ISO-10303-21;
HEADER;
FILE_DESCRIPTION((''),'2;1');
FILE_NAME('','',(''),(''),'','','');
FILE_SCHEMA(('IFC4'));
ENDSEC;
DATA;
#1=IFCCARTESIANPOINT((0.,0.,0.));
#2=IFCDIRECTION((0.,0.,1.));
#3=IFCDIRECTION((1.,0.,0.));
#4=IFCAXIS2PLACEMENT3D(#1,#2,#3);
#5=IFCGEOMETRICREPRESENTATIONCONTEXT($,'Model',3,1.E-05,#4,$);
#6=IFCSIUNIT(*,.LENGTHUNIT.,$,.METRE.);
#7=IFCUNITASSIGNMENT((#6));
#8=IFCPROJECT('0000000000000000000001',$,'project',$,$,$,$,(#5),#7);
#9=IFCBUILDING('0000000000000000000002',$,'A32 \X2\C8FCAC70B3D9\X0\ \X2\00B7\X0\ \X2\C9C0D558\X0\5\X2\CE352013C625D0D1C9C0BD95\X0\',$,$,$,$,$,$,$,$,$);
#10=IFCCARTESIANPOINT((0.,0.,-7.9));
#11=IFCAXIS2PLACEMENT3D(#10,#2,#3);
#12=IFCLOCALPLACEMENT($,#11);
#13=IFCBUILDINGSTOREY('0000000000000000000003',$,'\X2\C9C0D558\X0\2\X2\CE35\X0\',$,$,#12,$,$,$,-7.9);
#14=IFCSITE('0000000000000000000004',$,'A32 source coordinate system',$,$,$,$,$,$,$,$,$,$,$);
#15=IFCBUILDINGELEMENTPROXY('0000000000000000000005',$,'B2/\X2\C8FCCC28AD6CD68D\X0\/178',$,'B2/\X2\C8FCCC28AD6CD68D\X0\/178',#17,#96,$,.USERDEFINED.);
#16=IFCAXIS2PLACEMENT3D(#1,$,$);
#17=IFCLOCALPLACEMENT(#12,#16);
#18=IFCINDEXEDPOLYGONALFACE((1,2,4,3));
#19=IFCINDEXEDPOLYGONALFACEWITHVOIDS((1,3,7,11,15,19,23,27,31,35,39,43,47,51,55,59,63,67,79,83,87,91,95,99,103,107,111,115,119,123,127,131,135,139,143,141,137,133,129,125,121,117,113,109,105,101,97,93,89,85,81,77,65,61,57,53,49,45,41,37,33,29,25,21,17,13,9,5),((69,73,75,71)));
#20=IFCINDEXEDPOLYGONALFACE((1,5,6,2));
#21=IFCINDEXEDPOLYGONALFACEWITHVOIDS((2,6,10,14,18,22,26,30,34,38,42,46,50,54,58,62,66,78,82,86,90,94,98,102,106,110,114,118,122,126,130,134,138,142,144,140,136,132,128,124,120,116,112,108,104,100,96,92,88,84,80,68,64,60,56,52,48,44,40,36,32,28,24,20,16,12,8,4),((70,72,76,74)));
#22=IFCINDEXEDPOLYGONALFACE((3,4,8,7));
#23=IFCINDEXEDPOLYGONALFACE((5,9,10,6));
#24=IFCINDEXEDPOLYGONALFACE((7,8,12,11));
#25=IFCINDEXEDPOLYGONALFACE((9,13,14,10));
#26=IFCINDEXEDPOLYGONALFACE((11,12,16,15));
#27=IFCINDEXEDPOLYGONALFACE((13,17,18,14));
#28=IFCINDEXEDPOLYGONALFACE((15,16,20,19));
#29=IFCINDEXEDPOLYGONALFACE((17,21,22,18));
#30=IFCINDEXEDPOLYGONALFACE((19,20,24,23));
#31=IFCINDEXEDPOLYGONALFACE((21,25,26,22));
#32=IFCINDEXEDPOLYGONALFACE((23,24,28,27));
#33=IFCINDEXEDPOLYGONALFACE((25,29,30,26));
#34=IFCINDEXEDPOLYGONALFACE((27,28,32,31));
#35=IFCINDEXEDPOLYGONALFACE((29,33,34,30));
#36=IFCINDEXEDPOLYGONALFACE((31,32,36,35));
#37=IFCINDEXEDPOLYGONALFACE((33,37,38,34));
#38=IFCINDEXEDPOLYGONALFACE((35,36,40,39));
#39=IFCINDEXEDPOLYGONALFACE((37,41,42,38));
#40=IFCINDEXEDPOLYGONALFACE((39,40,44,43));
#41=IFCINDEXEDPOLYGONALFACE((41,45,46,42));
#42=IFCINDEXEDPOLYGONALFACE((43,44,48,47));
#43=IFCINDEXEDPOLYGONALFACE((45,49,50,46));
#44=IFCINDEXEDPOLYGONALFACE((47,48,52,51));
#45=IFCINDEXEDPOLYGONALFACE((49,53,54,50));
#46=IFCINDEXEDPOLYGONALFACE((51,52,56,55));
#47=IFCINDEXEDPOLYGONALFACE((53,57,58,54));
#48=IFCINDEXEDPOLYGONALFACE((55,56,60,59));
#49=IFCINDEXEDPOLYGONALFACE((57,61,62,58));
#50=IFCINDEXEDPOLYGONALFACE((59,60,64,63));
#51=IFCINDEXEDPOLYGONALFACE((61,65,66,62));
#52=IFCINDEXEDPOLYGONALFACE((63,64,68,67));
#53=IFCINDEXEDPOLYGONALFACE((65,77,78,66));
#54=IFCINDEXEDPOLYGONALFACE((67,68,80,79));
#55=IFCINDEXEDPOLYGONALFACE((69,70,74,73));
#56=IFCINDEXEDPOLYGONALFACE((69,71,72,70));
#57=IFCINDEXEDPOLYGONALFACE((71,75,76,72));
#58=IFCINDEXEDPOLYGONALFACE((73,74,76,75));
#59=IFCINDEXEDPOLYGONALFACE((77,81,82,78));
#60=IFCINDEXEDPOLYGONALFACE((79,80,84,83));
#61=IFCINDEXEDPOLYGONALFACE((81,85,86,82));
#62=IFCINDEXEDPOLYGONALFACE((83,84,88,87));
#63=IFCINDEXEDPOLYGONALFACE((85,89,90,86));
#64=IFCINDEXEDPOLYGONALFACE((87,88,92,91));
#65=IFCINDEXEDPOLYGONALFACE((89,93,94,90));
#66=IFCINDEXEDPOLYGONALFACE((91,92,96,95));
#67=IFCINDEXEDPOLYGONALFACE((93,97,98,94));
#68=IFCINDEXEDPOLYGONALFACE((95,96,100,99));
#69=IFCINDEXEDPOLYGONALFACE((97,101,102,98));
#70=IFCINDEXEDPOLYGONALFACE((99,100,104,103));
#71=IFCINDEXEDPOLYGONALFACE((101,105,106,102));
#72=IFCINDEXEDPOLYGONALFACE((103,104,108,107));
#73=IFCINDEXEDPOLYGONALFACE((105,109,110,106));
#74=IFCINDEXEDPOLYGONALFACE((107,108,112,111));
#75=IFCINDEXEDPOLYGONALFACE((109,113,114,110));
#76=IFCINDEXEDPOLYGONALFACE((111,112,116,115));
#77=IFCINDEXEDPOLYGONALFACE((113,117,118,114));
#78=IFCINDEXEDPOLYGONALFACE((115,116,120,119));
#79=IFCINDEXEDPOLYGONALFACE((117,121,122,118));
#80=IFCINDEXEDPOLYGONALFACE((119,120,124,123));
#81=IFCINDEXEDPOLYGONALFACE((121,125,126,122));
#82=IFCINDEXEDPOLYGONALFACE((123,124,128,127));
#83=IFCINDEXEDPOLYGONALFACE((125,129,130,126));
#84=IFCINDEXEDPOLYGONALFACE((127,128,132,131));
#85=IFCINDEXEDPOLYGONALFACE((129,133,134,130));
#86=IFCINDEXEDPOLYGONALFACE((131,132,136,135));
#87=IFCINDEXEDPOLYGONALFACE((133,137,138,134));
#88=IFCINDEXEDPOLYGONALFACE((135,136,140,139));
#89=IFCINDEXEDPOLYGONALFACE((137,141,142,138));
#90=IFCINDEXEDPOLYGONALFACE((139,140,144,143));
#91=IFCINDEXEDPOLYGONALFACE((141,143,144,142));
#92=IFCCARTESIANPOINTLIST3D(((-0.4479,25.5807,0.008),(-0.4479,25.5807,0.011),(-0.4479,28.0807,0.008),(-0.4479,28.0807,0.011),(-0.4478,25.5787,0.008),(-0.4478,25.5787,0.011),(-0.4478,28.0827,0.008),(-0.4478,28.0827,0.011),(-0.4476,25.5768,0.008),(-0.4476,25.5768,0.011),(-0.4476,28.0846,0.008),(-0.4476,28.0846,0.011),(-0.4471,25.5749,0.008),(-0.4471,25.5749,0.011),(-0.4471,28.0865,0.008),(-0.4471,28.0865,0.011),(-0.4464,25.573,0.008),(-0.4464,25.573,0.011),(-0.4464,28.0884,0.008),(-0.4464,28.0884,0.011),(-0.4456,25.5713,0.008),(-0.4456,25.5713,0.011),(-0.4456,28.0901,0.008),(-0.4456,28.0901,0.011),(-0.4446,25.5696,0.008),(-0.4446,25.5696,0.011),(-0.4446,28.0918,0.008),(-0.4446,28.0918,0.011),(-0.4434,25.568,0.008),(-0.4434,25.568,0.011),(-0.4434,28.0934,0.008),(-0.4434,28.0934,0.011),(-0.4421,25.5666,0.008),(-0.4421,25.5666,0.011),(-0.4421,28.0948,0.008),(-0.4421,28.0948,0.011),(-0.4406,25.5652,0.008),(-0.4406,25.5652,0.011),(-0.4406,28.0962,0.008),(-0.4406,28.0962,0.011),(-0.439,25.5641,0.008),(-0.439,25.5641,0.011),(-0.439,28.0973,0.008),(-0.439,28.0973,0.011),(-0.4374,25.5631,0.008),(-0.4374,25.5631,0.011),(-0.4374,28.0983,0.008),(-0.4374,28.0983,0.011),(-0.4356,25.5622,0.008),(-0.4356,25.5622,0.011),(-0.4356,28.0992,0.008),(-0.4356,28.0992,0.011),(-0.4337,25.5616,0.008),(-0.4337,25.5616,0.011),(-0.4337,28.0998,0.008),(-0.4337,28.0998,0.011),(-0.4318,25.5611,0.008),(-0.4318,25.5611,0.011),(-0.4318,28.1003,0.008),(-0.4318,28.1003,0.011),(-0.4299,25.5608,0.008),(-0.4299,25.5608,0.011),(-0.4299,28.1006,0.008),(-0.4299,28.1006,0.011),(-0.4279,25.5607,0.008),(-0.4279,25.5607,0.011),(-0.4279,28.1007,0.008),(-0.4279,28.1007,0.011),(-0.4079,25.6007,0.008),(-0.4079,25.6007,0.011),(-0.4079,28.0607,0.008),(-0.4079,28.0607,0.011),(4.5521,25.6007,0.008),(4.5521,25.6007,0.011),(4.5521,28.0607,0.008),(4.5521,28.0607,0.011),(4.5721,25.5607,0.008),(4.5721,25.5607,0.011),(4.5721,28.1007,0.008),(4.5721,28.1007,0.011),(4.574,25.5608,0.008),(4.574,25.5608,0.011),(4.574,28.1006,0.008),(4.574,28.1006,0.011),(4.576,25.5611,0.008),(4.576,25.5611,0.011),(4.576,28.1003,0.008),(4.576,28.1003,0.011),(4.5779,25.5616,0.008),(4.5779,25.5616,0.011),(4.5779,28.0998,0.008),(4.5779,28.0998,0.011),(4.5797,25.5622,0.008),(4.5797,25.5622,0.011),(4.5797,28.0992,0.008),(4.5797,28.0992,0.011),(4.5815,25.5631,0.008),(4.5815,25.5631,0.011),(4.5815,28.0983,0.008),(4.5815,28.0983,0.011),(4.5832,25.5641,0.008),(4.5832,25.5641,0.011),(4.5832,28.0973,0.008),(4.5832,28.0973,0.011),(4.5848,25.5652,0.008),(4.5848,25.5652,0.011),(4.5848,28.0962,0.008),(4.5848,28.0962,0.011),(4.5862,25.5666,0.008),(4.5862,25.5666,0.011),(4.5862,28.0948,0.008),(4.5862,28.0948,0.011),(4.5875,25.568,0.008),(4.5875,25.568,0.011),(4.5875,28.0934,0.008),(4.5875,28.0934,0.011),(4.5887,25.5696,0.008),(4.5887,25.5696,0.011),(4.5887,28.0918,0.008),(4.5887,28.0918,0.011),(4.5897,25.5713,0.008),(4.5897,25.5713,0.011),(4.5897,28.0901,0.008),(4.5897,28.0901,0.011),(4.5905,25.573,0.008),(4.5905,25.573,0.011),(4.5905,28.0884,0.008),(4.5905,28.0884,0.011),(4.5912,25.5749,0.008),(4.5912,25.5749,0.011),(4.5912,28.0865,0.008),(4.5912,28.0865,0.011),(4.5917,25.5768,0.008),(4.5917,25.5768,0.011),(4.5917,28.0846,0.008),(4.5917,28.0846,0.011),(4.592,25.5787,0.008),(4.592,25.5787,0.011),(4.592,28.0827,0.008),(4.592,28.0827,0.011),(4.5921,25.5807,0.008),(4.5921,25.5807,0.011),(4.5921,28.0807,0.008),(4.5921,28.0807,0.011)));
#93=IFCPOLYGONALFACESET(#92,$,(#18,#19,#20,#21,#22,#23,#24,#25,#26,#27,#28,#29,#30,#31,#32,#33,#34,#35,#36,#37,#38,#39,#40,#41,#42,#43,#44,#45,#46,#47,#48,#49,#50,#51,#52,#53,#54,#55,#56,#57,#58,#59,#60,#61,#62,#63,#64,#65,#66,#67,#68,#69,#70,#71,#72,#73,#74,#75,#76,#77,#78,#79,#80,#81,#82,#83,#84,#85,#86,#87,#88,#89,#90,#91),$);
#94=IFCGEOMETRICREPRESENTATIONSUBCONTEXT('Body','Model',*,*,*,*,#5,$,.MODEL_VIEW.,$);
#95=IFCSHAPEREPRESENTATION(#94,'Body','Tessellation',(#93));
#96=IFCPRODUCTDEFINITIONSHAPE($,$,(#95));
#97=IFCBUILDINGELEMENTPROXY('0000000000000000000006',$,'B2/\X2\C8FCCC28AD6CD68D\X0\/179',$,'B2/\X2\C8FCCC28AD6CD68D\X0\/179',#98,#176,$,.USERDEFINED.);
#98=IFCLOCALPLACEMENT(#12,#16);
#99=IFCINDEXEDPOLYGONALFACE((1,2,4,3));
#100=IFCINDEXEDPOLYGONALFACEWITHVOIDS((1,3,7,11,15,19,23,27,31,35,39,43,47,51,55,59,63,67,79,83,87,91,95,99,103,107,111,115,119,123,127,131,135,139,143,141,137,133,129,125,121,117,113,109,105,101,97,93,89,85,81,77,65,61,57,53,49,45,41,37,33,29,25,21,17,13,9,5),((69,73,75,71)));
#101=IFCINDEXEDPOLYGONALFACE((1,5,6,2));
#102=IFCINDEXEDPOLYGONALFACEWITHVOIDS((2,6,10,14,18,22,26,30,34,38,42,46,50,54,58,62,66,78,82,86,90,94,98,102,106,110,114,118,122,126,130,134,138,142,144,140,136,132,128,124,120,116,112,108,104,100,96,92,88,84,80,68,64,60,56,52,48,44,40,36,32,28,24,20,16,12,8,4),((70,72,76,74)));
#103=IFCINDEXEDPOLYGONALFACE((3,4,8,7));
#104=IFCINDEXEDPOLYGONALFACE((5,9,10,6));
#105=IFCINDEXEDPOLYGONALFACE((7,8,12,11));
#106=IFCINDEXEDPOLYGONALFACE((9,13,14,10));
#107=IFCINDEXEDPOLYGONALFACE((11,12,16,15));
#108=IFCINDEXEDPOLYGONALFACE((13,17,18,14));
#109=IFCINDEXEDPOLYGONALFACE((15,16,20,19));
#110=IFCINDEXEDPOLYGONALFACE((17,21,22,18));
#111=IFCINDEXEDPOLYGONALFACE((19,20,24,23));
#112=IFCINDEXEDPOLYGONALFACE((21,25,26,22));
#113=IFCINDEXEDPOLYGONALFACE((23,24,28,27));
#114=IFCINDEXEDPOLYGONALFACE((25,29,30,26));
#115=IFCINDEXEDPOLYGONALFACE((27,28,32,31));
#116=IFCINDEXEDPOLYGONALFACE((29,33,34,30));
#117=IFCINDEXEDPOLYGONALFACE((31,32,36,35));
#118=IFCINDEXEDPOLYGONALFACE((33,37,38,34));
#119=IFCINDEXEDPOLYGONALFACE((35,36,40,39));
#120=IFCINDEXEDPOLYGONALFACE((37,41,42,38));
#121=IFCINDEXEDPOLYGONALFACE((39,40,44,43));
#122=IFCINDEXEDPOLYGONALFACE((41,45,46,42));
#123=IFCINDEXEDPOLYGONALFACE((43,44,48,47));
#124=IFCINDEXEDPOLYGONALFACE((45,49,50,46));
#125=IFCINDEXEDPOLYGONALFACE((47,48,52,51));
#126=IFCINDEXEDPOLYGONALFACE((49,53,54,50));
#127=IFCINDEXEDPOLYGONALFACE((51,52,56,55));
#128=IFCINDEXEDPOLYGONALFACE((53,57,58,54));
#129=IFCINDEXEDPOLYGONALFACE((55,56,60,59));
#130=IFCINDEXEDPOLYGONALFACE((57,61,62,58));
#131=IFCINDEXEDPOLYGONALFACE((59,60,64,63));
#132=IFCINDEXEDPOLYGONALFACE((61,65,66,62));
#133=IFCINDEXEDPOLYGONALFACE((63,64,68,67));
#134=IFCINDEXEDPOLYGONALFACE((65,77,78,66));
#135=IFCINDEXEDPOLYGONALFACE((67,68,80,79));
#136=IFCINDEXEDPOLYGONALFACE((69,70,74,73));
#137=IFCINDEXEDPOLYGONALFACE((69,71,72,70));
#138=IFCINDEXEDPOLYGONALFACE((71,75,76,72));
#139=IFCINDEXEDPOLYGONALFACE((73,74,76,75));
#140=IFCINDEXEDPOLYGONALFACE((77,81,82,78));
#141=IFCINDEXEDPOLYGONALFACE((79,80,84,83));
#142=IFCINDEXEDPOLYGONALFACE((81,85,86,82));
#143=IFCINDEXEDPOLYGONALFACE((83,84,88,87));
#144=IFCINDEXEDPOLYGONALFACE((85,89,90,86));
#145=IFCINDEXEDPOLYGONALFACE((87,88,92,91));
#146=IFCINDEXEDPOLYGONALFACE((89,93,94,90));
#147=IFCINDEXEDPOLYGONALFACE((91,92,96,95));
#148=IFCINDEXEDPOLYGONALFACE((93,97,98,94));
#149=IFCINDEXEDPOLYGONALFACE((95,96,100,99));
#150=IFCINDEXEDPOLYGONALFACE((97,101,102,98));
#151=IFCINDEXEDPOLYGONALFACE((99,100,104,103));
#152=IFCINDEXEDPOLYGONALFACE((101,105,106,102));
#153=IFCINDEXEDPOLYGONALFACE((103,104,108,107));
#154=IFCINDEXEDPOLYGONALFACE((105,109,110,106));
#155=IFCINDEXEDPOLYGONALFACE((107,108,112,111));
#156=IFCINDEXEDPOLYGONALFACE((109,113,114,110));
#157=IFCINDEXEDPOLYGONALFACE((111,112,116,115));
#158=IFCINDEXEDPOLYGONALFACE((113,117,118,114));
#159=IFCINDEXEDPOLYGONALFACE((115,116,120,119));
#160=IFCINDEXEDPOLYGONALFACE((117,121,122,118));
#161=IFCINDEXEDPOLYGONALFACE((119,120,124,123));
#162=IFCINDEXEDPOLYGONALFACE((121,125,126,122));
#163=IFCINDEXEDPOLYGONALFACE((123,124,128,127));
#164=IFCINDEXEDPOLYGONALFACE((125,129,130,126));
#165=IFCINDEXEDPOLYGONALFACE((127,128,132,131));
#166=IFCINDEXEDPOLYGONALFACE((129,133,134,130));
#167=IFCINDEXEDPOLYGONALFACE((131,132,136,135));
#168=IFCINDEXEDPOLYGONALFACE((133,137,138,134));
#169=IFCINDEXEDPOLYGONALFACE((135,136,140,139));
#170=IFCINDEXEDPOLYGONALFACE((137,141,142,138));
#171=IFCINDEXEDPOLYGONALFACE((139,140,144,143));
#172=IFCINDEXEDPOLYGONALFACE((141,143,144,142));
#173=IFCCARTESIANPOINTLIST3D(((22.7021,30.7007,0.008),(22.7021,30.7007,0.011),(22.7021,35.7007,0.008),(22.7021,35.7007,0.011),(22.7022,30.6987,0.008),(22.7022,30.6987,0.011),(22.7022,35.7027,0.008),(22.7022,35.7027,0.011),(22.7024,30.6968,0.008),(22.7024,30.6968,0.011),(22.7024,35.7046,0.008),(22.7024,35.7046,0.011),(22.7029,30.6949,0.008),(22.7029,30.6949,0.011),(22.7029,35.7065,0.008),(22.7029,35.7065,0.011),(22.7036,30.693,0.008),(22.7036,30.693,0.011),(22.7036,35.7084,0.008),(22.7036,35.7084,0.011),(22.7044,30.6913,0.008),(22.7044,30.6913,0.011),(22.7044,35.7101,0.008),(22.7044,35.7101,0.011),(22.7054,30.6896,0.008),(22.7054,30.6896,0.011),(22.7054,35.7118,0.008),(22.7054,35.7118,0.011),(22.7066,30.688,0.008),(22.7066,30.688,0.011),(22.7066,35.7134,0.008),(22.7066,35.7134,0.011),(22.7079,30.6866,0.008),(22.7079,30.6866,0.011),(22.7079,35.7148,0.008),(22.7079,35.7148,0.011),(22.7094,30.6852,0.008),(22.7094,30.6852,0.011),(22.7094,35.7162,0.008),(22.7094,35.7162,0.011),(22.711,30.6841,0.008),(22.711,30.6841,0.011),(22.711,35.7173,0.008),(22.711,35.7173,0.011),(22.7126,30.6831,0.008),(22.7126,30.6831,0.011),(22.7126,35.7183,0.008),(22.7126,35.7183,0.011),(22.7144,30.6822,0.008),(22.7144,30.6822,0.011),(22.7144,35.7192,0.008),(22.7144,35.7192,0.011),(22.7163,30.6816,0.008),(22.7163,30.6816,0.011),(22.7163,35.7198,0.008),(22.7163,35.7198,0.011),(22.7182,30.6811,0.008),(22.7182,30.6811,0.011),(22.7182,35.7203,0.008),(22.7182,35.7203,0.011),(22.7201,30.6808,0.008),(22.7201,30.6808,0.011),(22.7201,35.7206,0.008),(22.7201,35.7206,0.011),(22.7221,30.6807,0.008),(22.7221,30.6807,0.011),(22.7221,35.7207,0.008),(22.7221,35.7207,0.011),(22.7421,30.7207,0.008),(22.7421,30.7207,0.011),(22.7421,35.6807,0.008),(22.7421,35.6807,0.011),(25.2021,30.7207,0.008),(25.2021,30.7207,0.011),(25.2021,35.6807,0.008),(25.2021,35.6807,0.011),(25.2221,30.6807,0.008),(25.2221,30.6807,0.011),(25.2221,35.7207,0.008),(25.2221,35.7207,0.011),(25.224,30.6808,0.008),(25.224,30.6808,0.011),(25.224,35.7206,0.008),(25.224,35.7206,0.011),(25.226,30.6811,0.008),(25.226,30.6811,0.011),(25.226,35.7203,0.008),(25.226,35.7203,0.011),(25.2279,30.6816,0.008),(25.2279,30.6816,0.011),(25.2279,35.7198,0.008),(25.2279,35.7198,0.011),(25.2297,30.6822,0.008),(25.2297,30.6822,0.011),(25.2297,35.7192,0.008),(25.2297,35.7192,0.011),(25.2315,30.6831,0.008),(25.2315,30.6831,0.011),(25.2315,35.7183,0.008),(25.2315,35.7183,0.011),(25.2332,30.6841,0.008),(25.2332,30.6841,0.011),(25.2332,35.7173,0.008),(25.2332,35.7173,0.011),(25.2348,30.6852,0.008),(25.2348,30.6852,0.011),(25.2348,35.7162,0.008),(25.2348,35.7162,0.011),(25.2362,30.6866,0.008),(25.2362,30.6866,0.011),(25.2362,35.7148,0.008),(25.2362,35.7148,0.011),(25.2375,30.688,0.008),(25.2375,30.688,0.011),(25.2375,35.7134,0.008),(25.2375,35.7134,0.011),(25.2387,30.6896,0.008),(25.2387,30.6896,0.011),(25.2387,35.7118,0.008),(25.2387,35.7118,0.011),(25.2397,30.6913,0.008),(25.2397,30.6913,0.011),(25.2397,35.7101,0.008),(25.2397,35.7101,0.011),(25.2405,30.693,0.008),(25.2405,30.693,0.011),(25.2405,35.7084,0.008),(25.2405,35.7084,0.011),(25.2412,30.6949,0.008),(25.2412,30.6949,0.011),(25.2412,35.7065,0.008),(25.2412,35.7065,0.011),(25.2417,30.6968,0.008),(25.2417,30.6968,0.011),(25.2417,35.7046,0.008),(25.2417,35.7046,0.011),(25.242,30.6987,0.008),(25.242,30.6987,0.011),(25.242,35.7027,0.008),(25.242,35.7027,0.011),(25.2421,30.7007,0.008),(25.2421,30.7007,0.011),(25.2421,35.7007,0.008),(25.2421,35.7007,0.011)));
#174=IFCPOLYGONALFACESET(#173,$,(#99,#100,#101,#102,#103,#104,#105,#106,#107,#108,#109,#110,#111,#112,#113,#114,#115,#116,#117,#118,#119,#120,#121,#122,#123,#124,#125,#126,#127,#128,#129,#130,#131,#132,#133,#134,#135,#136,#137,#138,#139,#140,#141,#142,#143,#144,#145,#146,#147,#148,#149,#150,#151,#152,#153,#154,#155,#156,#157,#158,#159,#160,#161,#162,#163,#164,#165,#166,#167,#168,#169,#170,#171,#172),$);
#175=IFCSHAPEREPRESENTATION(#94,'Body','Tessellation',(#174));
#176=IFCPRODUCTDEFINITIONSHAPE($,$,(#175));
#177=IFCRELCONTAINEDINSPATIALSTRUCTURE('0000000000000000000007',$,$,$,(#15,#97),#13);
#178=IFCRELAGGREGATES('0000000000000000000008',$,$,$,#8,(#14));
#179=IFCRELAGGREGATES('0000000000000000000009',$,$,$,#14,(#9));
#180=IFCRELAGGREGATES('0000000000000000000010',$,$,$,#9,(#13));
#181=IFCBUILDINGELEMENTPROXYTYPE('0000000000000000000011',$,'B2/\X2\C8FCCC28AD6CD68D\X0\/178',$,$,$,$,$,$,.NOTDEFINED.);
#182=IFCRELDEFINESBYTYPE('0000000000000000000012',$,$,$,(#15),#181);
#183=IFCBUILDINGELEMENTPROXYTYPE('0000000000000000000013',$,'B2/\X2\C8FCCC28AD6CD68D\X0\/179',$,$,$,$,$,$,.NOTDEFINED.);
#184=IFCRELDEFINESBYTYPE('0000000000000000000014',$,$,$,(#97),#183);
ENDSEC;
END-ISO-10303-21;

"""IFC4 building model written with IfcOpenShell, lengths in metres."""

from ifc_helpers import new_model, si_unit, frame, origin, origin_with_axes, place, context, subcontext, project, spatial, polyline, outline, extrude, source, transform, mapped, type_object, type_shapes, element, save


model = new_model("IFC4")

# Units and contexts
model_context = context("Model", 3, precision=1e-05, world=origin_with_axes())
body_context = subcontext(model_context, "Body", "Model", "MODEL_VIEW")
ifc_project = project(units=[si_unit("LENGTHUNIT", "METRE")], contexts=[model_context])

# Site, building, storey
site = spatial("IfcSite", under=ifc_project, Name="A32 source coordinate system")
building = spatial("IfcBuilding", under=site, Name="A32 주거동 · 지하5층–옥탑지붕")
storey_placement = place(None, frame((0.0, 0.0, -7.9), z_axis=(0.0, 0.0, 1.0), x_axis=(1.0, 0.0, 0.0)))
storey = spatial("IfcBuildingStorey", under=building, at=storey_placement, Name="지하2층", Elevation=-7.9)

# Building element proxies
building_element_proxy_type_1 = type_object("IfcBuildingElementProxyType", Name="B2/주차구획/178", PredefinedType="NOTDEFINED")
shared_shape_1 = source(origin(), body_context, "Body", "SweptSolid", [
    extrude(outline(polyline([(-0.4279, 25.5607), (-0.4299, 25.5608), (-0.4318, 25.5611), (-0.4337, 25.5616), (-0.4356, 25.5622), (-0.4374, 25.5631), (-0.439, 25.5641), (-0.4406, 25.5652), (-0.4421, 25.5666), (-0.4434, 25.568), (-0.4446, 25.5696), (-0.4456, 25.5713), (-0.4464, 25.573), (-0.4471, 25.5749), (-0.4476, 25.5768), (-0.4478, 25.5787), (-0.4479, 25.5807), (-0.4479, 28.0807), (-0.4478, 28.0827), (-0.4476, 28.0846), (-0.4471, 28.0865), (-0.4464, 28.0884), (-0.4456, 28.0901), (-0.4446, 28.0918), (-0.4434, 28.0934), (-0.4421, 28.0948), (-0.4406, 28.0962), (-0.439, 28.0973), (-0.4374, 28.0983), (-0.4356, 28.0992), (-0.4337, 28.0998), (-0.4318, 28.1003), (-0.4299, 28.1006), (-0.4279, 28.1007), (4.5721, 28.1007), (4.574, 28.1006), (4.576, 28.1003), (4.5779, 28.0998), (4.5797, 28.0992), (4.5815, 28.0983), (4.5832, 28.0973), (4.5848, 28.0962), (4.5862, 28.0948), (4.5875, 28.0934), (4.5887, 28.0918), (4.5897, 28.0901), (4.5905, 28.0884), (4.5912, 28.0865), (4.5917, 28.0846), (4.592, 28.0827), (4.5921, 28.0807), (4.5921, 25.5807), (4.592, 25.5787), (4.5917, 25.5768), (4.5912, 25.5749), (4.5905, 25.573), (4.5897, 25.5713), (4.5887, 25.5696), (4.5875, 25.568), (4.5862, 25.5666), (4.5848, 25.5652), (4.5832, 25.5641), (4.5815, 25.5631), (4.5797, 25.5622), (4.5779, 25.5616), (4.576, 25.5611), (4.574, 25.5608), (4.5721, 25.5607), (-0.4279, 25.5607)]), holes=[polyline([(-0.4079, 25.6007), (4.5521, 25.6007), (4.5521, 28.0607), (-0.4079, 28.0607), (-0.4079, 25.6007)])]), frame((0.0, 0.0, 0.008)), (0.0, 0.0, 1.0), 0.003),
])
type_shapes(building_element_proxy_type_1, [shared_shape_1])
proxy_1_placement = place(storey_placement, origin_with_axes())
element("IfcBuildingElementProxy", 1, at=proxy_1_placement, inside=storey, type_object=building_element_proxy_type_1, Name="B2/주차구획/178", ObjectType="B2/주차구획/178", PredefinedType="USERDEFINED", context=body_context, shape_type="MappedRepresentation", body=[
    mapped(shared_shape_1, transform((0.0, 0.0, 0.0), scale=1.0)),
])
building_element_proxy_type_2 = type_object("IfcBuildingElementProxyType", Name="B2/주차구획/179", PredefinedType="NOTDEFINED")
shared_shape_2 = source(origin(), body_context, "Body", "SweptSolid", [
    extrude(outline(polyline([(22.7021, 35.7007), (22.7022, 35.7027), (22.7024, 35.7046), (22.7029, 35.7065), (22.7036, 35.7084), (22.7044, 35.7101), (22.7054, 35.7118), (22.7066, 35.7134), (22.7079, 35.7148), (22.7094, 35.7162), (22.711, 35.7173), (22.7126, 35.7183), (22.7144, 35.7192), (22.7163, 35.7198), (22.7182, 35.7203), (22.7201, 35.7206), (22.7221, 35.7207), (25.2221, 35.7207), (25.224, 35.7206), (25.226, 35.7203), (25.2279, 35.7198), (25.2297, 35.7192), (25.2315, 35.7183), (25.2332, 35.7173), (25.2348, 35.7162), (25.2362, 35.7148), (25.2375, 35.7134), (25.2387, 35.7118), (25.2397, 35.7101), (25.2405, 35.7084), (25.2412, 35.7065), (25.2417, 35.7046), (25.242, 35.7027), (25.2421, 35.7007), (25.2421, 30.7007), (25.242, 30.6987), (25.2417, 30.6968), (25.2412, 30.6949), (25.2405, 30.693), (25.2397, 30.6913), (25.2387, 30.6896), (25.2375, 30.688), (25.2362, 30.6866), (25.2348, 30.6852), (25.2332, 30.6841), (25.2315, 30.6831), (25.2297, 30.6822), (25.2279, 30.6816), (25.226, 30.6811), (25.224, 30.6808), (25.2221, 30.6807), (22.7221, 30.6807), (22.7201, 30.6808), (22.7182, 30.6811), (22.7163, 30.6816), (22.7144, 30.6822), (22.7126, 30.6831), (22.711, 30.6841), (22.7094, 30.6852), (22.7079, 30.6866), (22.7066, 30.688), (22.7054, 30.6896), (22.7044, 30.6913), (22.7036, 30.693), (22.7029, 30.6949), (22.7024, 30.6968), (22.7022, 30.6987), (22.7021, 30.7007), (22.7021, 35.7007)]), holes=[polyline([(22.7421, 35.6807), (22.7421, 30.7207), (25.2021, 30.7207), (25.2021, 35.6807), (22.7421, 35.6807)])]), frame((0.0, 0.0, 0.008)), (0.0, 0.0, 1.0), 0.003),
])
type_shapes(building_element_proxy_type_2, [shared_shape_2])
proxy_2_placement = place(storey_placement, origin_with_axes())
element("IfcBuildingElementProxy", 2, at=proxy_2_placement, inside=storey, type_object=building_element_proxy_type_2, Name="B2/주차구획/179", ObjectType="B2/주차구획/179", PredefinedType="USERDEFINED", context=body_context, shape_type="MappedRepresentation", body=[
    mapped(shared_shape_2, transform((0.0, 0.0, 0.0), scale=1.0)),
])

save(model, "model.ifc")
